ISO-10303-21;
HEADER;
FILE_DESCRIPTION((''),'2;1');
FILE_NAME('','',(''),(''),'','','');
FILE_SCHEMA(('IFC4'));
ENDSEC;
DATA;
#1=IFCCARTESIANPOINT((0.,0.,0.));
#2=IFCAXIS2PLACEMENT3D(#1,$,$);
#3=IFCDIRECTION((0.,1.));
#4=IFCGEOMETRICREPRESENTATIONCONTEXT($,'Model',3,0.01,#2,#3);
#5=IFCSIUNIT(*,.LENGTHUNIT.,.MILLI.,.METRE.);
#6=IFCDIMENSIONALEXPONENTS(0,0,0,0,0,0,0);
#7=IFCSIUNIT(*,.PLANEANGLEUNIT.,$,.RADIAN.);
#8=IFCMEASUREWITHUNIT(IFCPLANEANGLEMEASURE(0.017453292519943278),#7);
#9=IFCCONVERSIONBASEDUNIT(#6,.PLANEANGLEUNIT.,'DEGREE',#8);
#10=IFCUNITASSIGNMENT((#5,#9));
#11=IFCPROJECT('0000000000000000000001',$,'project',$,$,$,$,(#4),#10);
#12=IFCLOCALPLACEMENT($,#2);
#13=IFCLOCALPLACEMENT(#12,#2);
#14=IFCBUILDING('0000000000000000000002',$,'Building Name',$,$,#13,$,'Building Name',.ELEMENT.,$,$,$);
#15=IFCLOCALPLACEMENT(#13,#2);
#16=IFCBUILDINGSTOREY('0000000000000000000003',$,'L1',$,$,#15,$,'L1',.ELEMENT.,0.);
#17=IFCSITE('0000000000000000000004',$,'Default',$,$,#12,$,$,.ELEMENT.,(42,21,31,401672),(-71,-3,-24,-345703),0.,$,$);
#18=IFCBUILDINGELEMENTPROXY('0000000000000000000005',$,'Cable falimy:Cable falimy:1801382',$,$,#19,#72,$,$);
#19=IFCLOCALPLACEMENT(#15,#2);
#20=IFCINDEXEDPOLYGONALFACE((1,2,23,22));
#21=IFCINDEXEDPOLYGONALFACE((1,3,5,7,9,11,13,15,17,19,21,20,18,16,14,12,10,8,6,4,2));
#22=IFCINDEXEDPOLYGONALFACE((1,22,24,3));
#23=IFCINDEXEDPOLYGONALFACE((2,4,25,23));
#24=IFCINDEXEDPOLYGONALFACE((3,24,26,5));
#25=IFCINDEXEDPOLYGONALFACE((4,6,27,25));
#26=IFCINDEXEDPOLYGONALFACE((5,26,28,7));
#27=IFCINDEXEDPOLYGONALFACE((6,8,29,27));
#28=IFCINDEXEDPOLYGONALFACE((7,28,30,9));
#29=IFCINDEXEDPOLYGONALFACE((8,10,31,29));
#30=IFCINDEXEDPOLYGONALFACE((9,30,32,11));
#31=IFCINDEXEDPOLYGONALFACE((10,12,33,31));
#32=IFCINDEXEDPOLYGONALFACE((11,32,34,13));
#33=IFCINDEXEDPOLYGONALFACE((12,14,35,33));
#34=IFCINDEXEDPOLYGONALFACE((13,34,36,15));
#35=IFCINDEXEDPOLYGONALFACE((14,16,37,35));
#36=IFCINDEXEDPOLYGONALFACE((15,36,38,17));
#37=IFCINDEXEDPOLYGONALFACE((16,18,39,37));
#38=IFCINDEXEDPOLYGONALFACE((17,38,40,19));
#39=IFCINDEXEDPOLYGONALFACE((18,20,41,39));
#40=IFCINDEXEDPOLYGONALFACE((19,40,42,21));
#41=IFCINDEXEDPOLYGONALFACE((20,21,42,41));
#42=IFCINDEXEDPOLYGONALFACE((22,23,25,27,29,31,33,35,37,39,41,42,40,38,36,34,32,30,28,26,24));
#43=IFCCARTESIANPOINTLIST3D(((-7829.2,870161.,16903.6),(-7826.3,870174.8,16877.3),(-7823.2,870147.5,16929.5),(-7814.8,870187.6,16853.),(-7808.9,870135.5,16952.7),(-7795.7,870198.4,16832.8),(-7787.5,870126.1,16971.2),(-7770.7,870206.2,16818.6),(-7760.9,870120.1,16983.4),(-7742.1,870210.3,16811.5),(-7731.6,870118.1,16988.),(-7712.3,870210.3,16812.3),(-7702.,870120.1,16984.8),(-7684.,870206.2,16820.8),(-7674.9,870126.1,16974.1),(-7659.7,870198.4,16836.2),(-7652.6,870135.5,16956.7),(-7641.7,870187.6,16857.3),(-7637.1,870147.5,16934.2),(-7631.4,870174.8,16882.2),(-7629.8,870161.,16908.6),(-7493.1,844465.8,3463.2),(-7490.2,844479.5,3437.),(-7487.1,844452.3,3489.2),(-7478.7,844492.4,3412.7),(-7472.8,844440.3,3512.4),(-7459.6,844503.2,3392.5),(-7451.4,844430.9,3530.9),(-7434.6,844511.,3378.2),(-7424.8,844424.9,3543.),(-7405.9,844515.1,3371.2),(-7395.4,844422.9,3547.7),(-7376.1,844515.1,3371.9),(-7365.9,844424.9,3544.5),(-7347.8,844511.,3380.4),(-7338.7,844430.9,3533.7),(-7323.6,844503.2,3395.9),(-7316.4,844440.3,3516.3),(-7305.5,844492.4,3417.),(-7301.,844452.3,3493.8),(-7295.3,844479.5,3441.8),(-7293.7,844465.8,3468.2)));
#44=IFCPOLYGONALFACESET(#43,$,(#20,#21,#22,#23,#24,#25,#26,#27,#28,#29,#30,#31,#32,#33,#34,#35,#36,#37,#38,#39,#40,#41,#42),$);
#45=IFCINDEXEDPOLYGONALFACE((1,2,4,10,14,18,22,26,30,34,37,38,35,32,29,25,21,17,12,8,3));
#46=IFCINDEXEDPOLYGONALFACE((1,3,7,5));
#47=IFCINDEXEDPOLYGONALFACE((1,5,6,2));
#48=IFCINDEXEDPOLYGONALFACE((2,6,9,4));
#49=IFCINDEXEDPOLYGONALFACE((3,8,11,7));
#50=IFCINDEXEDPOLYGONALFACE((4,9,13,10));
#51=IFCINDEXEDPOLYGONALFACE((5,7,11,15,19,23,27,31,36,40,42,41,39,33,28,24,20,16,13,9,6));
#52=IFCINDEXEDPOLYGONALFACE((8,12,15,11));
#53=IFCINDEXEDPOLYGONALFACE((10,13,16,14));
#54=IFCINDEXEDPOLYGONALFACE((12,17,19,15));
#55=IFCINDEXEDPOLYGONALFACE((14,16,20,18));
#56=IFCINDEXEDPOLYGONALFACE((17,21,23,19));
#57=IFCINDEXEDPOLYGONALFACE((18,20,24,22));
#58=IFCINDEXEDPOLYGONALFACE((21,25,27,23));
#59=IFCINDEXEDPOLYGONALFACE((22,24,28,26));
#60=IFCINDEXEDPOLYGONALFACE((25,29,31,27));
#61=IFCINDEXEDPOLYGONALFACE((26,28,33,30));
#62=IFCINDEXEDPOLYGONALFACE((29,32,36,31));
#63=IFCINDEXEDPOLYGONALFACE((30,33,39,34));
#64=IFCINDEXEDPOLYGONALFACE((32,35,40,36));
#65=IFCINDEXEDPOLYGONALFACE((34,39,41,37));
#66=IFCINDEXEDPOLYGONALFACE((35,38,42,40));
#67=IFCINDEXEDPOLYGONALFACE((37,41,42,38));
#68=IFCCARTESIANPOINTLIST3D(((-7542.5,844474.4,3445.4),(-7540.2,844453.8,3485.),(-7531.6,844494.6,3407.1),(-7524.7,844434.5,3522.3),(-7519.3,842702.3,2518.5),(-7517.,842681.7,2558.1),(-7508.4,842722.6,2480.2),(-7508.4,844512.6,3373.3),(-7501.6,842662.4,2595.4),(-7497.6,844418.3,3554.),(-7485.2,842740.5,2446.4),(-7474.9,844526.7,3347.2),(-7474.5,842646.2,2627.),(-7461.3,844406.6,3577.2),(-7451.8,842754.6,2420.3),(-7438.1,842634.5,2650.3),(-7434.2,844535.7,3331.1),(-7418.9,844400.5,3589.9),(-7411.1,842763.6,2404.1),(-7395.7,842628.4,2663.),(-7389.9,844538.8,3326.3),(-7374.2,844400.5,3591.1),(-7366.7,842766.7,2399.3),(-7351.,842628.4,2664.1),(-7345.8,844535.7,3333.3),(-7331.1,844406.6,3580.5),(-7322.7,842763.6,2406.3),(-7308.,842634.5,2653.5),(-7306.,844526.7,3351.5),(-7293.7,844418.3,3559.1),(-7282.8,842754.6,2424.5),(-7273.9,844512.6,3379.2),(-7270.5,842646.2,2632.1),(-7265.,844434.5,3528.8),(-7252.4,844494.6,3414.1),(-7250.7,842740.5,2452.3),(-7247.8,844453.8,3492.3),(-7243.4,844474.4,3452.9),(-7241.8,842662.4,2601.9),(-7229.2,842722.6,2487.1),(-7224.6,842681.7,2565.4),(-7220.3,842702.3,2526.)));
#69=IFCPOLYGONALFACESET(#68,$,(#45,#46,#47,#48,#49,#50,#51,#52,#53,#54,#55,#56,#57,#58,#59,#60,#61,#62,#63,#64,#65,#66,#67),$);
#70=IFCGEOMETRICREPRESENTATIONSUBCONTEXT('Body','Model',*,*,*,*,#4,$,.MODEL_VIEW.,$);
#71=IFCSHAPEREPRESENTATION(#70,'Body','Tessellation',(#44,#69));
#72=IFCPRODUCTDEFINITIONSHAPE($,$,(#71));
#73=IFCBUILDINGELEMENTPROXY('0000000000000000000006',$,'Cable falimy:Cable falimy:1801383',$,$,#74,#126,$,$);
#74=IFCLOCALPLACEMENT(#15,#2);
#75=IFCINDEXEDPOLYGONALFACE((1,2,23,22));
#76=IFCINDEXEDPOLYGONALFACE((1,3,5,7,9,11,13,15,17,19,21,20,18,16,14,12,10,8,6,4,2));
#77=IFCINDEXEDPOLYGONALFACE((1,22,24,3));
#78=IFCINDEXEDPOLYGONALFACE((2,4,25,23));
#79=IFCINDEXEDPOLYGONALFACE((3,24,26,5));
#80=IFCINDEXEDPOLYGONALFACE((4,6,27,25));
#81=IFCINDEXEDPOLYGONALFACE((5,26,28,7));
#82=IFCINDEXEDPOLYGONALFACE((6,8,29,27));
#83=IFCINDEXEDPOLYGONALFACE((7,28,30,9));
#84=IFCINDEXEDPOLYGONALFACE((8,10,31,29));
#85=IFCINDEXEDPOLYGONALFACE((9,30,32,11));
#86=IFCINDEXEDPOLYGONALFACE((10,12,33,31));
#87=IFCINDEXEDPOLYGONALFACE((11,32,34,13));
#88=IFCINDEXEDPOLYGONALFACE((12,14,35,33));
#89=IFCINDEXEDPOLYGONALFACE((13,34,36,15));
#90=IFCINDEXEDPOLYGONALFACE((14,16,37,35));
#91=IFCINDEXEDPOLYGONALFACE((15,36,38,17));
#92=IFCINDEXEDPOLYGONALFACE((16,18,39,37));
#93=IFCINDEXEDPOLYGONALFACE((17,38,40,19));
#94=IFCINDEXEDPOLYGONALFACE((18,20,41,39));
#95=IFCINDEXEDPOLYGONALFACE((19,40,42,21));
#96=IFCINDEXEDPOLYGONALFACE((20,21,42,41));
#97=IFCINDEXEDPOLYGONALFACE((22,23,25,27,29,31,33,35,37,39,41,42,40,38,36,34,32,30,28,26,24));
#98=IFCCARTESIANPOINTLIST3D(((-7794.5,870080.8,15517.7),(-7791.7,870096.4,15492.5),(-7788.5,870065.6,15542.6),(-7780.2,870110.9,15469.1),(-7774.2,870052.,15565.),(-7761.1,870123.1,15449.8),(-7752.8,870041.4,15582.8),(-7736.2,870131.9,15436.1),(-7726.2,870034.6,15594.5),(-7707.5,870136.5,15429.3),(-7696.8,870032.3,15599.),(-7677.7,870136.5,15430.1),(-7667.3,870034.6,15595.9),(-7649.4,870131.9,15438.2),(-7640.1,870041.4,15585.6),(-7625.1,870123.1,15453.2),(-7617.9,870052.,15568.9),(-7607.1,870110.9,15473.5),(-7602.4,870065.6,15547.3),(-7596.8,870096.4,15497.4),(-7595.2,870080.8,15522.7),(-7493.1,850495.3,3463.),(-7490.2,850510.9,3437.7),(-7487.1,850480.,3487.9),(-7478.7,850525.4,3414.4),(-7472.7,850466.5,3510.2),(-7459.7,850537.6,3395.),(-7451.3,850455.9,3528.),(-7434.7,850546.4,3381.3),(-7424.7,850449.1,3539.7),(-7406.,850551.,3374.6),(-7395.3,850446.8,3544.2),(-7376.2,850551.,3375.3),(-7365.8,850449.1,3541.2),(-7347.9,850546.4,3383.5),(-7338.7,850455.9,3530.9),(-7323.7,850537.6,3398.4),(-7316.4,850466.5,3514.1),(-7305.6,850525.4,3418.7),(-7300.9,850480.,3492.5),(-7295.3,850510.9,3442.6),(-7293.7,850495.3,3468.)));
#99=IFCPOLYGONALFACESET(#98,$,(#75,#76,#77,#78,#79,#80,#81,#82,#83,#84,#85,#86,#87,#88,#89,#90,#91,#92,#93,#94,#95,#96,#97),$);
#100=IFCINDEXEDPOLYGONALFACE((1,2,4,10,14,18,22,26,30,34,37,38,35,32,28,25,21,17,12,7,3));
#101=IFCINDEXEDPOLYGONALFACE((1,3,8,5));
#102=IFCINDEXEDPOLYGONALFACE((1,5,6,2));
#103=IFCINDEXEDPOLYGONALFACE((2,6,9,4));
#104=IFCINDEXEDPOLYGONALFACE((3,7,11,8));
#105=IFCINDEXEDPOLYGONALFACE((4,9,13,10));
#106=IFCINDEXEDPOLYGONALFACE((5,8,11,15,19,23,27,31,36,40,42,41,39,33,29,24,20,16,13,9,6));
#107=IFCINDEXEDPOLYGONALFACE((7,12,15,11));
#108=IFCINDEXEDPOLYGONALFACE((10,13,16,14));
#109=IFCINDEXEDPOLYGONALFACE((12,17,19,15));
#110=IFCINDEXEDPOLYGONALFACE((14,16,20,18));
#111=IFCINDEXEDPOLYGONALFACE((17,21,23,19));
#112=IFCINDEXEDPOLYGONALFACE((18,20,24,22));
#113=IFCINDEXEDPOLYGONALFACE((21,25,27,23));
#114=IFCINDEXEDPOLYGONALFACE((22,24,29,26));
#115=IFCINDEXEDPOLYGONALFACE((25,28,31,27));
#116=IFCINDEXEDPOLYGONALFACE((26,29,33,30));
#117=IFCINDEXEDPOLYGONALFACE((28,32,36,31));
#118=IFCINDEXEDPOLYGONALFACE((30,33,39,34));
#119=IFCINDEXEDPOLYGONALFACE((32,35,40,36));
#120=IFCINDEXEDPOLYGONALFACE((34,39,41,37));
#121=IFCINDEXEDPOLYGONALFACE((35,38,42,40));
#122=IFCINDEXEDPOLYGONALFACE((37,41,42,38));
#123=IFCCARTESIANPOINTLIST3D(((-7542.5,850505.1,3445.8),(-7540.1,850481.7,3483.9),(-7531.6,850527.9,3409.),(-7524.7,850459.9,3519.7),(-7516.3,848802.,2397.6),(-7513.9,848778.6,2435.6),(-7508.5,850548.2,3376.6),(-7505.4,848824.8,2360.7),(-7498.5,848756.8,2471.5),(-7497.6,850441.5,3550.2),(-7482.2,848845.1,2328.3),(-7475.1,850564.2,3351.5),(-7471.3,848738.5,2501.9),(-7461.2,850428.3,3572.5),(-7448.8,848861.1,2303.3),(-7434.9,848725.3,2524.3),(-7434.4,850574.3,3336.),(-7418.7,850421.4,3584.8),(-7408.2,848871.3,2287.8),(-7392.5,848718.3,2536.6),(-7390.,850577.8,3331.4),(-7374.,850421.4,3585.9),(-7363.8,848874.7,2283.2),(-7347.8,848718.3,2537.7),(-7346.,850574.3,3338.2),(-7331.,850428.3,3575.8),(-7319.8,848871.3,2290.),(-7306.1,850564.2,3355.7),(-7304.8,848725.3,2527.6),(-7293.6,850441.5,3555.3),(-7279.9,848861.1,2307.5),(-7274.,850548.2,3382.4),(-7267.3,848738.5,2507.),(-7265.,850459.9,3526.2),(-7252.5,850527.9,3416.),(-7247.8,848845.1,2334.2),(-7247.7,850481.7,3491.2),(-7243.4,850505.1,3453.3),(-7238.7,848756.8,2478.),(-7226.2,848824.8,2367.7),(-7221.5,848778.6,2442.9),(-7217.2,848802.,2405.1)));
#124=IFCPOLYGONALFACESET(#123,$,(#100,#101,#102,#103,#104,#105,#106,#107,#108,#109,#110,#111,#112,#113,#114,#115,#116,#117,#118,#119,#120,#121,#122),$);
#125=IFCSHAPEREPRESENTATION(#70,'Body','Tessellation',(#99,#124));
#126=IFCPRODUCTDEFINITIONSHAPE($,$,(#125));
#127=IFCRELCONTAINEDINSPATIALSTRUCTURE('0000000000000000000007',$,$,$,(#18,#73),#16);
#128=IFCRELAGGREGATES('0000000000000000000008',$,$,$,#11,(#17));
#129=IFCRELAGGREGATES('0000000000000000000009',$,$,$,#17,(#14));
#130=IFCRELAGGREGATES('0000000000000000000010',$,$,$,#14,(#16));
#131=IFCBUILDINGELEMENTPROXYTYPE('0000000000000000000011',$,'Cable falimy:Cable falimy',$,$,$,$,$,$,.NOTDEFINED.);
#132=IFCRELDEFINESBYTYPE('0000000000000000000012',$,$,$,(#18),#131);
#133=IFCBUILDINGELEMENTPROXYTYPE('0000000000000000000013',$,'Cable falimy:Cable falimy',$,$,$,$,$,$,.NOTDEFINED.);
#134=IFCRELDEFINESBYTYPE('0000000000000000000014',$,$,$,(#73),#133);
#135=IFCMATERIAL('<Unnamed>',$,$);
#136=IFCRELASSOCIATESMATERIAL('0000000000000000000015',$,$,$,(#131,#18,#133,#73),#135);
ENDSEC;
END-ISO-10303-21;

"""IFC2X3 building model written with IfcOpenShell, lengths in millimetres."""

from ifc_helpers import new_model, entity, si_unit, converted_unit, direction, frame, frame_2d, origin, place, context, subcontext, project, spatial, circle, extrude, source, transform, mapped, material, type_object, type_shapes, element, save


model = new_model("IFC2X3")

# Units and contexts
model_context = context("Model", 3, precision=0.01, world=origin(), true_north=direction((0.0, 1.0)))
body_context = subcontext(model_context, "Body", "Model", "MODEL_VIEW")
ifc_project = project(units=[si_unit("LENGTHUNIT", "METRE", prefix="MILLI"), converted_unit("PLANEANGLEUNIT", "DEGREE", entity("IfcPlaneAngleMeasure", 0.017453292519943278), si_unit("PLANEANGLEUNIT", "RADIAN"), dimensions=[0, 0, 0, 0, 0, 0, 0])], contexts=[model_context])

# Site, building, storey
site_placement = place(None, origin())
site = spatial("IfcSite", under=ifc_project, at=site_placement, Name="Default", CompositionType="ELEMENT", RefLatitude=(42, 21, 31, 401672), RefLongitude=(-71, -3, -24, -345703), RefElevation=0.0)
building_placement = place(site_placement, origin())
building = spatial("IfcBuilding", under=site, at=building_placement, Name="Building Name", LongName="Building Name", CompositionType="ELEMENT")
storey_placement = place(building_placement, origin())
storey = spatial("IfcBuildingStorey", under=building, at=storey_placement, Name="L1", LongName="L1", CompositionType="ELEMENT", Elevation=0.0)

# Shared definitions
ifc_material = material(Name="<Unnamed>")

# Building element proxies
building_element_proxy_type_1 = type_object("IfcBuildingElementProxyType", Name="Cable falimy:Cable falimy", PredefinedType="NOTDEFINED", material=ifc_material)
shared_shape_1 = source(origin(), body_context, "Body", "SweptSolid", [
    extrude(circle(Radius=100.0, at=frame_2d((0.0, 0.0), x_axis=(1.0, 0.0))), frame((0.0, 0.0, 0.0), z_axis=(0.886042, 0.0, 0.463605), x_axis=(-0.463605, 0.0, 0.886042)), (0.0, 0.0, 1.0), 29000.0),
    extrude(circle(Radius=150.0, at=frame_2d((0.0, 0.0), x_axis=(1.0, 0.0))), frame((-1772.1, 0.0, -927.2), z_axis=(0.886042, 0.0, 0.463605), x_axis=(0.463605, 0.0, -0.886042)), (0.0, 0.0, 1.0), 2000.0),
])
type_shapes(building_element_proxy_type_1, [shared_shape_1])
proxy_1_placement = place(storey_placement, frame((-7393.2, 844469.2, 3459.1), z_axis=(-0.025001, 0.0, 0.999687), x_axis=(0.0, 1.0, 0.0)))
element("IfcBuildingElementProxy", 1, at=proxy_1_placement, inside=storey, type_object=building_element_proxy_type_1, material=ifc_material, Name="Cable falimy:Cable falimy:1801382", context=body_context, shape_type="MappedRepresentation", body=[
    mapped(shared_shape_1, transform((0.0, 0.0, 0.0), scale=1.0)),
])
building_element_proxy_type_2 = type_object("IfcBuildingElementProxyType", Name="Cable falimy:Cable falimy", PredefinedType="NOTDEFINED", material=ifc_material)
shared_shape_2 = source(origin(), body_context, "Body", "SweptSolid", [
    extrude(circle(Radius=100.0, at=frame_2d((0.0, 0.0), x_axis=(1.0, 0.0))), frame((0.0, 0.0, 0.0), z_axis=(0.851544, 0.0, 0.524283), x_axis=(-0.524283, 0.0, 0.851544)), (0.0, 0.0, 1.0), 23000.0),
    extrude(circle(Radius=150.0, at=frame_2d((0.0, 0.0), x_axis=(1.0, 0.0))), frame((-1703.1, 0.0, -1048.6), z_axis=(0.851544, 0.0, 0.524283), x_axis=(0.524283, 0.0, -0.851544)), (0.0, 0.0, 1.0), 2000.0),
])
type_shapes(building_element_proxy_type_2, [shared_shape_2])
proxy_2_placement = place(storey_placement, frame((-7393.2, 850499.2, 3459.1), z_axis=(-0.025001, 0.0, 0.999687), x_axis=(0.0, 1.0, 0.0)))
element("IfcBuildingElementProxy", 2, at=proxy_2_placement, inside=storey, type_object=building_element_proxy_type_2, material=ifc_material, Name="Cable falimy:Cable falimy:1801383", context=body_context, shape_type="MappedRepresentation", body=[
    mapped(shared_shape_2, transform((0.0, 0.0, 0.0), scale=1.0)),
])

save(model, "model.ifc")
